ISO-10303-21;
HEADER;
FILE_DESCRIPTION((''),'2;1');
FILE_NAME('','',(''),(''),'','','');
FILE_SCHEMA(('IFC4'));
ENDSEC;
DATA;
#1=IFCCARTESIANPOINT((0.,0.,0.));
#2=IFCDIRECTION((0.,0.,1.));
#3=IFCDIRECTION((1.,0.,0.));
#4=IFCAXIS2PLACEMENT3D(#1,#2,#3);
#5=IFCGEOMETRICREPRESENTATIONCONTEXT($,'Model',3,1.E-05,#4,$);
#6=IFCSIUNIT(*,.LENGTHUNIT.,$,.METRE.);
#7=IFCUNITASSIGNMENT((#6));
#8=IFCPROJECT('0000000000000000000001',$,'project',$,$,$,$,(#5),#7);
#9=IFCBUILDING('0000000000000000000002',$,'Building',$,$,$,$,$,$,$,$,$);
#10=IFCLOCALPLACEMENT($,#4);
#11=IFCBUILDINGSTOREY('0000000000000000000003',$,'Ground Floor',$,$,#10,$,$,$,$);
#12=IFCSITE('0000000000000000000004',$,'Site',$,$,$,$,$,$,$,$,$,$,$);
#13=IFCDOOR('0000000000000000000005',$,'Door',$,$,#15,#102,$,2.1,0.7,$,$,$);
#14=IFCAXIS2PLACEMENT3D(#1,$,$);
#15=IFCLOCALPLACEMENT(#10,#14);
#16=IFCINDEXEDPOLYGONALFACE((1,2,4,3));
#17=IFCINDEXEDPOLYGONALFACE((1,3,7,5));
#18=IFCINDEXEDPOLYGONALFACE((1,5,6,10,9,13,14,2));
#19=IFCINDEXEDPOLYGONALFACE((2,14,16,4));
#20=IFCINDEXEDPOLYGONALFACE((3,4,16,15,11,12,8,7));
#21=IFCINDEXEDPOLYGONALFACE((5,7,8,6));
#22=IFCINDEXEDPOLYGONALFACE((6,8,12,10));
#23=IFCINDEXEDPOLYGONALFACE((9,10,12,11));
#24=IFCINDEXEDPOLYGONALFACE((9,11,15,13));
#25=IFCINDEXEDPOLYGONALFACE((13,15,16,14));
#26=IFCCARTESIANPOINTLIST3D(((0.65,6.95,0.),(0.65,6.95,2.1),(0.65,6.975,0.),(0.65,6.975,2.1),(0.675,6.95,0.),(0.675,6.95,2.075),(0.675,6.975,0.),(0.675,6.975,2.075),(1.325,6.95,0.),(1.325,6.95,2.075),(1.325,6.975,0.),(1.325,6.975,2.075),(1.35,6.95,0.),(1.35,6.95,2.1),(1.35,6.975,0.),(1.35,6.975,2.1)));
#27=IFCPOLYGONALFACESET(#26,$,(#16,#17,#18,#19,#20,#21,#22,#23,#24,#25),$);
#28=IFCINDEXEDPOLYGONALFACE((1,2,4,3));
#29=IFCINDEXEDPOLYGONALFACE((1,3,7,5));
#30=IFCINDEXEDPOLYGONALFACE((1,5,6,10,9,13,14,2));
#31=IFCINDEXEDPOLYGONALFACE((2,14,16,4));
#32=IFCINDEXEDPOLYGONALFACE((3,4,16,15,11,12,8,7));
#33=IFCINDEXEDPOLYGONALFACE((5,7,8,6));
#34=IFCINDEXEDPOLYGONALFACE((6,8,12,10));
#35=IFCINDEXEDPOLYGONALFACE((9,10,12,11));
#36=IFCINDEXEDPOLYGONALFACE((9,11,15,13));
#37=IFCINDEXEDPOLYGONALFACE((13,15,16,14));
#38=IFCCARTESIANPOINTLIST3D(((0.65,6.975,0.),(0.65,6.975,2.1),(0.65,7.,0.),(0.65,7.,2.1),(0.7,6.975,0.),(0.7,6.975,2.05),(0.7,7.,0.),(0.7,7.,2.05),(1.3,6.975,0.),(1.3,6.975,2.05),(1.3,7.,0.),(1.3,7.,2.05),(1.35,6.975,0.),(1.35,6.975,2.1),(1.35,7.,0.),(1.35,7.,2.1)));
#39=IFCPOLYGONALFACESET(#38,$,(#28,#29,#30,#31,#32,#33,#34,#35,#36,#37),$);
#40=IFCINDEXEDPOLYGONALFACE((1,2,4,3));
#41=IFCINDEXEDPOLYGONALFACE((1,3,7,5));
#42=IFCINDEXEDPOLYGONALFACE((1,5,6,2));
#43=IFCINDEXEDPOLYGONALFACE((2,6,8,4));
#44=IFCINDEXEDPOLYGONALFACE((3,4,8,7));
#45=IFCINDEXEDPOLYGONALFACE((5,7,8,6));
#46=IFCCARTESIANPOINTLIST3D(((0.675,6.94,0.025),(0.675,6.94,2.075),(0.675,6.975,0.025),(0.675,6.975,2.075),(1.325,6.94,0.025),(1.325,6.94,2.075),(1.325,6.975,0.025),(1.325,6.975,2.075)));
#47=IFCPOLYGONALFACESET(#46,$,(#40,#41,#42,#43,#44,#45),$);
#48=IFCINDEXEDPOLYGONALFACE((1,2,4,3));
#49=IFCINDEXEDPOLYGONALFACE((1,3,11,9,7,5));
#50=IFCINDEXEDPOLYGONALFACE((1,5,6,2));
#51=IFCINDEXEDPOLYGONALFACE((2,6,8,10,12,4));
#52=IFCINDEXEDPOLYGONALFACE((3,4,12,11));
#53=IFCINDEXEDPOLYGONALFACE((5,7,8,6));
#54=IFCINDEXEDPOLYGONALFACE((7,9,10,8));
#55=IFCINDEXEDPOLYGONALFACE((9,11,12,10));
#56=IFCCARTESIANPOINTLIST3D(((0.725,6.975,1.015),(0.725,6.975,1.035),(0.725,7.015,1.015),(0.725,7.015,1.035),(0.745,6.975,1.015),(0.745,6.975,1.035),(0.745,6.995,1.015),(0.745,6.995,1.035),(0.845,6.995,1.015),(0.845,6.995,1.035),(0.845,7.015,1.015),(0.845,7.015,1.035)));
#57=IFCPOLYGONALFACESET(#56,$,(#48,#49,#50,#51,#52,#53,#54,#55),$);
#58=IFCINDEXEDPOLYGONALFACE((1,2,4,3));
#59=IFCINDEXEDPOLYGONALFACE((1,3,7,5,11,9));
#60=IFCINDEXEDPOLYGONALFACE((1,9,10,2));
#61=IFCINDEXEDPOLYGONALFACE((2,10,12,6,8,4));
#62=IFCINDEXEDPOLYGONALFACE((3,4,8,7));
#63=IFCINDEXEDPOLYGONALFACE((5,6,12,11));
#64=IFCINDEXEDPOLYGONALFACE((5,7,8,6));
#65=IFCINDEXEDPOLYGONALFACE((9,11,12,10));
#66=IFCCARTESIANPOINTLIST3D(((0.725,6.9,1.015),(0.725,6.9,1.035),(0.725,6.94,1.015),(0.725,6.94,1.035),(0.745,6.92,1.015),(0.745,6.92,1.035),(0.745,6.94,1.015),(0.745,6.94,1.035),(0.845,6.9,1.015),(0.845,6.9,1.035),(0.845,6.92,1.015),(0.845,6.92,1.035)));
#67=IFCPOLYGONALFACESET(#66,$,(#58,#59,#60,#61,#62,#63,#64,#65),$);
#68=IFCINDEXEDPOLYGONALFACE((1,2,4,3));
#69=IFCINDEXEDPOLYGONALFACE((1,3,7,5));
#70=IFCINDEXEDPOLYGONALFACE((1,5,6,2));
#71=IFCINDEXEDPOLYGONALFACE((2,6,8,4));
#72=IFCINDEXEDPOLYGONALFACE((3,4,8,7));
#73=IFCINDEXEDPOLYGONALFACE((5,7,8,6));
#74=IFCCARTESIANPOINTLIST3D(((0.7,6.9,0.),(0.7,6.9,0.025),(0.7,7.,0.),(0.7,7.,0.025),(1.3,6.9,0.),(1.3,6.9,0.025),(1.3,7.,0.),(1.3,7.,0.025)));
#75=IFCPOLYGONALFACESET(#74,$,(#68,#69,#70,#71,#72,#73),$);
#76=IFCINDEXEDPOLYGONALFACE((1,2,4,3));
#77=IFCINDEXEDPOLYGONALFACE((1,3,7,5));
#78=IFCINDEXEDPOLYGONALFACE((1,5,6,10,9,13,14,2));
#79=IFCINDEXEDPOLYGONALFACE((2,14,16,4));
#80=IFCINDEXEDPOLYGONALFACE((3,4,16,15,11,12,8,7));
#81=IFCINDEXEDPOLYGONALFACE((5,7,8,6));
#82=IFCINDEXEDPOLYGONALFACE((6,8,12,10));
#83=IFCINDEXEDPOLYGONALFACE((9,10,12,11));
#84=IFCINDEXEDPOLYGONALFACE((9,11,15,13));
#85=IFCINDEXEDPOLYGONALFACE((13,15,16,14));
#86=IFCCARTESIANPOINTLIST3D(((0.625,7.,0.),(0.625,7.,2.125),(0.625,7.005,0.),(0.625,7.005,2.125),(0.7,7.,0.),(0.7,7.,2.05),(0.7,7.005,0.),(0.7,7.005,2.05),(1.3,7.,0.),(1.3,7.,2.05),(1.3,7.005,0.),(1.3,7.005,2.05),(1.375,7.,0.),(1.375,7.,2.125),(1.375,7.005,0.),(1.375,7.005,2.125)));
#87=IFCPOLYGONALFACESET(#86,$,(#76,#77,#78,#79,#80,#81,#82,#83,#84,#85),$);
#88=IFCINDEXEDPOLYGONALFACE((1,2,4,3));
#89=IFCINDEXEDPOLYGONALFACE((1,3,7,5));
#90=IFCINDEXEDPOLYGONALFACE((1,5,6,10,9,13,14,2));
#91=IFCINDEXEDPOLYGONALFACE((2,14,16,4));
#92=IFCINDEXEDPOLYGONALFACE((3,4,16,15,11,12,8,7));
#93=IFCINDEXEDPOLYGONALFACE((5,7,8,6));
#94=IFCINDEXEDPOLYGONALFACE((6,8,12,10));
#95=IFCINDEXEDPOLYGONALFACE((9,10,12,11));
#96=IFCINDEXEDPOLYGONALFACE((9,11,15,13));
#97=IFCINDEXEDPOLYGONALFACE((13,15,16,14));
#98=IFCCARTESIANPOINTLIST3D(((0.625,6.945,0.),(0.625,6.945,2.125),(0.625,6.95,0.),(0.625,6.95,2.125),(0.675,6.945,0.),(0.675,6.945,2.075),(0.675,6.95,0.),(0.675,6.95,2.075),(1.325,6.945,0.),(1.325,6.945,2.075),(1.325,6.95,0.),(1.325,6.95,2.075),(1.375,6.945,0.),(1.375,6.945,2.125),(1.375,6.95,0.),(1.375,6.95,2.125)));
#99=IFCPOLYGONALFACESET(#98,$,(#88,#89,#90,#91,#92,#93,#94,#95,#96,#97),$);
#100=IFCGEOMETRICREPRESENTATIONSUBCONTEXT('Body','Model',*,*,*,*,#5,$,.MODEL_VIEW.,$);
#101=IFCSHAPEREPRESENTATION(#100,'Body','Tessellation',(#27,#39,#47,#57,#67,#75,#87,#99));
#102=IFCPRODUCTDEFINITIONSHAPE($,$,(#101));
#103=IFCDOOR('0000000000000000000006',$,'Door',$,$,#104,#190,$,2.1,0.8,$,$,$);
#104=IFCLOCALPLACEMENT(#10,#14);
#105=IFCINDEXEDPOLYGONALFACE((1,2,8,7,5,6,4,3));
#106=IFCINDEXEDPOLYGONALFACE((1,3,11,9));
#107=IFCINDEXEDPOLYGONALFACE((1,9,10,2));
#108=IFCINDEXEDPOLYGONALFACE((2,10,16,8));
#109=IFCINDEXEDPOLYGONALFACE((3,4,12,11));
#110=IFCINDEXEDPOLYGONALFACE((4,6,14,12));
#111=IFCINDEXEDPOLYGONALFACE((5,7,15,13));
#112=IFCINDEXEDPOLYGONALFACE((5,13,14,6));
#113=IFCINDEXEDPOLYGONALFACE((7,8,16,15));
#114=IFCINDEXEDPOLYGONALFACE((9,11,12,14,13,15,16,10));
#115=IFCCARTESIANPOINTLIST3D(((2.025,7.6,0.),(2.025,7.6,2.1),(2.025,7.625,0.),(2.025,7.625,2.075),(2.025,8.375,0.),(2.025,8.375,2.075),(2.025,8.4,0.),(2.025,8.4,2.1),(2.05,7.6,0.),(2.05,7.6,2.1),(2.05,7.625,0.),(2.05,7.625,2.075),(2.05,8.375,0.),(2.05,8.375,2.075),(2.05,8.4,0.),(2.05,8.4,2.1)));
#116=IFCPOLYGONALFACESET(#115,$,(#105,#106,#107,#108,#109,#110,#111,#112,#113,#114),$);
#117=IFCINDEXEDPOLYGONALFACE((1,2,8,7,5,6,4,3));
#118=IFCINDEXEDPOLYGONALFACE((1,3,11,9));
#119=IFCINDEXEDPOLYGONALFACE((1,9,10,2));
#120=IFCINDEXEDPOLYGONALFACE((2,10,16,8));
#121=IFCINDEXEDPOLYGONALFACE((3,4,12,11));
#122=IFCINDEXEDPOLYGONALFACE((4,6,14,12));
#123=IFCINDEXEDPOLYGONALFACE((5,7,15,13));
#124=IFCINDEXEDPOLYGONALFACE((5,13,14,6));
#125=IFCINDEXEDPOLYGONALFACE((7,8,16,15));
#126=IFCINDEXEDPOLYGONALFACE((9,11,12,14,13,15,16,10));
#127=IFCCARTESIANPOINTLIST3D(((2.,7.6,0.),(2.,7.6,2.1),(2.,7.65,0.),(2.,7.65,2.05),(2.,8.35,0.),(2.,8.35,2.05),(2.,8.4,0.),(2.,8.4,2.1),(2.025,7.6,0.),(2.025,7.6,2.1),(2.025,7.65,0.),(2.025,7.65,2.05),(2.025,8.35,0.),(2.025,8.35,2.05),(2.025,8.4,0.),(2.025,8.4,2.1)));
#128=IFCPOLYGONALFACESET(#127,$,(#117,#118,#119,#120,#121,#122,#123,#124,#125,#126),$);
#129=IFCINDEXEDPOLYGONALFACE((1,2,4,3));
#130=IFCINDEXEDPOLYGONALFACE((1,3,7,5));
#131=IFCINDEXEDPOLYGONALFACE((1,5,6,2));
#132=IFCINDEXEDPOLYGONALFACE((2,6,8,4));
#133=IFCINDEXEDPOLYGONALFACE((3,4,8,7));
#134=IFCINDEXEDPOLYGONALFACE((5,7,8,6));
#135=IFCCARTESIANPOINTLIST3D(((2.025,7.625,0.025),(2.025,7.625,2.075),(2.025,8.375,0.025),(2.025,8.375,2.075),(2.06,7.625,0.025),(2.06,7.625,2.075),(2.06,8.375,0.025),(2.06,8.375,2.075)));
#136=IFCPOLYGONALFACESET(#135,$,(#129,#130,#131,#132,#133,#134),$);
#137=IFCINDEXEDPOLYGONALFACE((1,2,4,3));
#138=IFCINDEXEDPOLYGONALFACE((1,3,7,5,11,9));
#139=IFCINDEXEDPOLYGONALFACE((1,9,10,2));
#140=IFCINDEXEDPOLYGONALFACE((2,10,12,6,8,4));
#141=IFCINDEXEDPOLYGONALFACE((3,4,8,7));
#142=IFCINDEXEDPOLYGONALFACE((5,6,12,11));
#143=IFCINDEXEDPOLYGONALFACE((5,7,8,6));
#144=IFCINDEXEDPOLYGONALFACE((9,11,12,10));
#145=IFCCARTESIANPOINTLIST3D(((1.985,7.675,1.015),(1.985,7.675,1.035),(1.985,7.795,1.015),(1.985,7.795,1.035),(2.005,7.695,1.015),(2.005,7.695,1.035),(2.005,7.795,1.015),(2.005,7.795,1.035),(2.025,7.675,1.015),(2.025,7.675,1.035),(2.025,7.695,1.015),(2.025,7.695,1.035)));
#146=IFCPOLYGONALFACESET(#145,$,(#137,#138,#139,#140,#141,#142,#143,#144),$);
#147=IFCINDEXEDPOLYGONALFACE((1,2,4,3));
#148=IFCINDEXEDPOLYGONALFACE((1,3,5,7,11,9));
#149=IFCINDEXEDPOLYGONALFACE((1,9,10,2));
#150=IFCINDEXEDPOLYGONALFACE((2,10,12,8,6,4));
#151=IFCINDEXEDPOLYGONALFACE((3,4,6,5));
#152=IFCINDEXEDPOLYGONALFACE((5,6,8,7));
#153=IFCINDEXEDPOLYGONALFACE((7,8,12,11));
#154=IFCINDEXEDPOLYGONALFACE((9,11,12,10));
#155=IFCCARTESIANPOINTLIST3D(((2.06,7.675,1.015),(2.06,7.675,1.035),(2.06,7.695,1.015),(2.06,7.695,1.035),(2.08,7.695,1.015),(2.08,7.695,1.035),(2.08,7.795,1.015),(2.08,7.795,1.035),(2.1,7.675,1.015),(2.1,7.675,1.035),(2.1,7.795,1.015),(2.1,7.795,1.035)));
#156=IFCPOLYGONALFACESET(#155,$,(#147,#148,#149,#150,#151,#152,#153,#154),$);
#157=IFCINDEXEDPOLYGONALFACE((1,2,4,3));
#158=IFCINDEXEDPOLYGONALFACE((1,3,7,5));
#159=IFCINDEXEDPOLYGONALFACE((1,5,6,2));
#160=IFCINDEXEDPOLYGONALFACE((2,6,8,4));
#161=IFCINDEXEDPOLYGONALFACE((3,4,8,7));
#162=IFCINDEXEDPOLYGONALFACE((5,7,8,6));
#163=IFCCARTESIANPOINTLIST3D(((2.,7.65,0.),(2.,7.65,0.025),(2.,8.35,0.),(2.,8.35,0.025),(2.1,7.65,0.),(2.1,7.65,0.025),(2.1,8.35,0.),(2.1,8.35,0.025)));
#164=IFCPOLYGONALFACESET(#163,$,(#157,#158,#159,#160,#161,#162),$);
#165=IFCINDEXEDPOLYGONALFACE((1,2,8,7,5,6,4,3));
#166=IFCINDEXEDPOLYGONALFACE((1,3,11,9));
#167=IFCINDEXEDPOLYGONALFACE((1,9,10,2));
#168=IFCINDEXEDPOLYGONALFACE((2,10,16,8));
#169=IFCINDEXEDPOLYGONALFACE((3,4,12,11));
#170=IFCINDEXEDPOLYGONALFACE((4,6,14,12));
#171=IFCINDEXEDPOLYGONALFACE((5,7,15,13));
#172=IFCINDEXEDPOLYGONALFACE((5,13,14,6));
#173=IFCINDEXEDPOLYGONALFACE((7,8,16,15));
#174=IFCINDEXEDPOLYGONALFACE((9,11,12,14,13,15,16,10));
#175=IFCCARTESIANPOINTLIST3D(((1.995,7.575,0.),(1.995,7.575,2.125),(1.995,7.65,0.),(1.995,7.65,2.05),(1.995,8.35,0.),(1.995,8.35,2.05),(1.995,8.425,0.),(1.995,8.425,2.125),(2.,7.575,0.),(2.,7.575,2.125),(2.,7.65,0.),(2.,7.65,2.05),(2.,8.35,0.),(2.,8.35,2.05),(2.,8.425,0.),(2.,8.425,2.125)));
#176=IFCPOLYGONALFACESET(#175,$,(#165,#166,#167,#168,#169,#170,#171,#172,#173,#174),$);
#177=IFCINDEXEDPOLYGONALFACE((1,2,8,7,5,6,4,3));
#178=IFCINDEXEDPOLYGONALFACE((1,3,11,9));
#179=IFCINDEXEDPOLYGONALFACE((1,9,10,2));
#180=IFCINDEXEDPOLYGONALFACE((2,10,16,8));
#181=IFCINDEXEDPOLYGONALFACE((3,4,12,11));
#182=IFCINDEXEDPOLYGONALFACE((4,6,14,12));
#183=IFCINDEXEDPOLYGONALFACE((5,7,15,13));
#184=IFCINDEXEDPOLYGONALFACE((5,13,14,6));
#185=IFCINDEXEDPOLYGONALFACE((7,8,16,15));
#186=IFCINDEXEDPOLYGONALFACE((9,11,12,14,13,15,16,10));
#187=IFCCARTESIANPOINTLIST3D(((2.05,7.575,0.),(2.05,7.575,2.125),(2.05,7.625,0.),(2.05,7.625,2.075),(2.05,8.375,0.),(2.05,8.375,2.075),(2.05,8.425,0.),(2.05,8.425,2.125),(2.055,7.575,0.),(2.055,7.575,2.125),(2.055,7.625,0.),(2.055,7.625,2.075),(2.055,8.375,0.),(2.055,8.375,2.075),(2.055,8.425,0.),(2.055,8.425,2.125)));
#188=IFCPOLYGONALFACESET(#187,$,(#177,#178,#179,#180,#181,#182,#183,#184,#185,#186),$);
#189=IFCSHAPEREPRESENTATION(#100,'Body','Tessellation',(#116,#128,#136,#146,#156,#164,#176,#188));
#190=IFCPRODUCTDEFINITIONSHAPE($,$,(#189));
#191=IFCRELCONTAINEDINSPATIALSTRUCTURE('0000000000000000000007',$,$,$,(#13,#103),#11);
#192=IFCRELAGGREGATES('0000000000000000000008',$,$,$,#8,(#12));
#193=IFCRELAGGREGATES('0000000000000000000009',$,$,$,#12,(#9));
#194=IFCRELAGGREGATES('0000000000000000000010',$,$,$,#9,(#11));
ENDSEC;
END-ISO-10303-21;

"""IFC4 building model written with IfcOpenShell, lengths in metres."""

from ifc_helpers import new_model, si_unit, frame, origin_with_axes, place, context, subcontext, project, spatial, line, indexed_curve, outline, extrude, element, save


model = new_model("IFC4")

# Units and contexts
model_context = context("Model", 3, precision=1e-05, world=origin_with_axes())
body_context = subcontext(model_context, "Body", "Model", "MODEL_VIEW")
ifc_project = project(units=[si_unit("LENGTHUNIT", "METRE")], contexts=[model_context])

# Site, building, storey
site = spatial("IfcSite", under=ifc_project, Name="Site")
building = spatial("IfcBuilding", under=site, Name="Building")
storey_placement = place(None, origin_with_axes())
storey = spatial("IfcBuildingStorey", under=building, at=storey_placement, Name="Ground Floor")

# Doors
door_1_placement = place(storey_placement, frame((1.35, 7.0, 0.0), z_axis=(0.0, 0.0, 1.0), x_axis=(-1.0, 0.0, 0.0)))
element("IfcDoor", 1, at=door_1_placement, inside=storey, Name="Door", OverallHeight=2.1, OverallWidth=0.7, context=body_context, shape_type="SweptSolid", body=[
    extrude(outline(indexed_curve([(0.0, 0.0), (0.0, 2.1), (0.7, 2.1), (0.7, 0.0), (0.675, 0.0), (0.675, 2.075), (0.025, 2.075), (0.025, 0.0)], segments=[line(1, 2, 3, 4, 5, 6, 7, 8, 1)])), frame((0.0, 0.025, 0.0), z_axis=(0.0, -1.0, 0.0), x_axis=(1.0, 0.0, 0.0)), (0.0, 0.0, -1.0), 0.025),
    extrude(outline(indexed_curve([(0.0, 0.0), (0.0, 2.1), (0.7, 2.1), (0.7, 0.0), (0.65, 0.0), (0.65, 2.05), (0.05, 2.05), (0.05, 0.0)], segments=[line(1, 2, 3, 4, 5, 6, 7, 8, 1)])), frame((0.0, 0.0, 0.0), z_axis=(0.0, -1.0, 0.0), x_axis=(1.0, 0.0, 0.0)), (0.0, 0.0, -1.0), 0.025),
    extrude(outline(indexed_curve([(0.0, 0.0), (0.65, 0.0), (0.65, 0.035), (0.0, 0.035)], segments=[line(1, 2, 3, 4, 1)])), frame((0.025, 0.025, 0.025), z_axis=(0.0, 0.0, 1.0), x_axis=(1.0, 0.0, 0.0)), (0.0, 0.0, 1.0), 2.05),
    extrude(outline(indexed_curve([(0.0, 0.0), (0.0, -0.04), (-0.12, -0.04), (-0.12, -0.02), (-0.02, -0.02), (-0.02, 0.0)], segments=[line(1, 2, 3, 4, 5, 6, 1)])), frame((0.625, 0.025, 1.015), z_axis=(0.0, 0.0, 1.0), x_axis=(1.0, 0.0, 0.0)), (0.0, 0.0, 1.0), 0.02),
    extrude(outline(indexed_curve([(0.0, 0.0), (0.0, 0.04), (-0.12, 0.04), (-0.12, 0.02), (-0.02, 0.02), (-0.02, 0.0)], segments=[line(1, 2, 3, 4, 5, 6, 1)])), frame((0.625, 0.06, 1.015), z_axis=(0.0, 0.0, 1.0), x_axis=(1.0, 0.0, 0.0)), (0.0, 0.0, 1.0), 0.02),
    extrude(outline(indexed_curve([(0.0, 0.0), (0.6, 0.0), (0.6, 0.1), (0.0, 0.1)], segments=[line(1, 2, 3, 4, 1)])), frame((0.05, 0.0, 0.0), z_axis=(0.0, 0.0, 1.0), x_axis=(1.0, 0.0, 0.0)), (0.0, 0.0, 1.0), 0.025),
    extrude(outline(indexed_curve([(0.0, 0.0), (0.0, 2.125), (0.75, 2.125), (0.75, 0.0), (0.675, 0.0), (0.675, 2.05), (0.075, 2.05), (0.075, 0.0)], segments=[line(1, 2, 3, 4, 5, 6, 7, 8, 1)])), frame((-0.025, -0.005, 0.0), z_axis=(0.0, -1.0, 0.0), x_axis=(1.0, 0.0, 0.0)), (0.0, 0.0, -1.0), 0.005),
    extrude(outline(indexed_curve([(0.0, 0.0), (0.0, 2.125), (0.75, 2.125), (0.75, 0.0), (0.7, 0.0), (0.7, 2.075), (0.05, 2.075), (0.05, 0.0)], segments=[line(1, 2, 3, 4, 5, 6, 7, 8, 1)])), frame((-0.025, 0.05, 0.0), z_axis=(0.0, -1.0, 0.0), x_axis=(1.0, 0.0, 0.0)), (0.0, 0.0, -1.0), 0.005),
])
door_2_placement = place(storey_placement, frame((2.0, 8.4, 0.0), z_axis=(0.0, 0.0, 1.0), x_axis=(0.0, -1.0, 0.0)))
element("IfcDoor", 2, at=door_2_placement, inside=storey, Name="Door", OverallHeight=2.1, OverallWidth=0.8, context=body_context, shape_type="SweptSolid", body=[
    extrude(outline(indexed_curve([(0.0, 0.0), (0.0, 2.1), (0.8, 2.1), (0.8, 0.0), (0.775, 0.0), (0.775, 2.075), (0.025, 2.075), (0.025, 0.0)], segments=[line(1, 2, 3, 4, 5, 6, 7, 8, 1)])), frame((0.0, 0.025, 0.0), z_axis=(0.0, -1.0, 0.0), x_axis=(1.0, 0.0, 0.0)), (0.0, 0.0, -1.0), 0.025),
    extrude(outline(indexed_curve([(0.0, 0.0), (0.0, 2.1), (0.8, 2.1), (0.8, 0.0), (0.75, 0.0), (0.75, 2.05), (0.05, 2.05), (0.05, 0.0)], segments=[line(1, 2, 3, 4, 5, 6, 7, 8, 1)])), frame((0.0, 0.0, 0.0), z_axis=(0.0, -1.0, 0.0), x_axis=(1.0, 0.0, 0.0)), (0.0, 0.0, -1.0), 0.025),
    extrude(outline(indexed_curve([(0.0, 0.0), (0.75, 0.0), (0.75, 0.035), (0.0, 0.035)], segments=[line(1, 2, 3, 4, 1)])), frame((0.025, 0.025, 0.025), z_axis=(0.0, 0.0, 1.0), x_axis=(1.0, 0.0, 0.0)), (0.0, 0.0, 1.0), 2.05),
    extrude(outline(indexed_curve([(0.0, 0.0), (0.0, -0.04), (-0.12, -0.04), (-0.12, -0.02), (-0.02, -0.02), (-0.02, 0.0)], segments=[line(1, 2, 3, 4, 5, 6, 1)])), frame((0.725, 0.025, 1.015), z_axis=(0.0, 0.0, 1.0), x_axis=(1.0, 0.0, 0.0)), (0.0, 0.0, 1.0), 0.02),
    extrude(outline(indexed_curve([(0.0, 0.0), (0.0, 0.04), (-0.12, 0.04), (-0.12, 0.02), (-0.02, 0.02), (-0.02, 0.0)], segments=[line(1, 2, 3, 4, 5, 6, 1)])), frame((0.725, 0.06, 1.015), z_axis=(0.0, 0.0, 1.0), x_axis=(1.0, 0.0, 0.0)), (0.0, 0.0, 1.0), 0.02),
    extrude(outline(indexed_curve([(0.0, 0.0), (0.7, 0.0), (0.7, 0.1), (0.0, 0.1)], segments=[line(1, 2, 3, 4, 1)])), frame((0.05, 0.0, 0.0), z_axis=(0.0, 0.0, 1.0), x_axis=(1.0, 0.0, 0.0)), (0.0, 0.0, 1.0), 0.025),
    extrude(outline(indexed_curve([(0.0, 0.0), (0.0, 2.125), (0.85, 2.125), (0.85, 0.0), (0.775, 0.0), (0.775, 2.05), (0.075, 2.05), (0.075, 0.0)], segments=[line(1, 2, 3, 4, 5, 6, 7, 8, 1)])), frame((-0.025, -0.005, 0.0), z_axis=(0.0, -1.0, 0.0), x_axis=(1.0, 0.0, 0.0)), (0.0, 0.0, -1.0), 0.005),
    extrude(outline(indexed_curve([(0.0, 0.0), (0.0, 2.125), (0.85, 2.125), (0.85, 0.0), (0.8, 0.0), (0.8, 2.075), (0.05, 2.075), (0.05, 0.0)], segments=[line(1, 2, 3, 4, 5, 6, 7, 8, 1)])), frame((-0.025, 0.05, 0.0), z_axis=(0.0, -1.0, 0.0), x_axis=(1.0, 0.0, 0.0)), (0.0, 0.0, -1.0), 0.005),
])

save(model, "model.ifc")
